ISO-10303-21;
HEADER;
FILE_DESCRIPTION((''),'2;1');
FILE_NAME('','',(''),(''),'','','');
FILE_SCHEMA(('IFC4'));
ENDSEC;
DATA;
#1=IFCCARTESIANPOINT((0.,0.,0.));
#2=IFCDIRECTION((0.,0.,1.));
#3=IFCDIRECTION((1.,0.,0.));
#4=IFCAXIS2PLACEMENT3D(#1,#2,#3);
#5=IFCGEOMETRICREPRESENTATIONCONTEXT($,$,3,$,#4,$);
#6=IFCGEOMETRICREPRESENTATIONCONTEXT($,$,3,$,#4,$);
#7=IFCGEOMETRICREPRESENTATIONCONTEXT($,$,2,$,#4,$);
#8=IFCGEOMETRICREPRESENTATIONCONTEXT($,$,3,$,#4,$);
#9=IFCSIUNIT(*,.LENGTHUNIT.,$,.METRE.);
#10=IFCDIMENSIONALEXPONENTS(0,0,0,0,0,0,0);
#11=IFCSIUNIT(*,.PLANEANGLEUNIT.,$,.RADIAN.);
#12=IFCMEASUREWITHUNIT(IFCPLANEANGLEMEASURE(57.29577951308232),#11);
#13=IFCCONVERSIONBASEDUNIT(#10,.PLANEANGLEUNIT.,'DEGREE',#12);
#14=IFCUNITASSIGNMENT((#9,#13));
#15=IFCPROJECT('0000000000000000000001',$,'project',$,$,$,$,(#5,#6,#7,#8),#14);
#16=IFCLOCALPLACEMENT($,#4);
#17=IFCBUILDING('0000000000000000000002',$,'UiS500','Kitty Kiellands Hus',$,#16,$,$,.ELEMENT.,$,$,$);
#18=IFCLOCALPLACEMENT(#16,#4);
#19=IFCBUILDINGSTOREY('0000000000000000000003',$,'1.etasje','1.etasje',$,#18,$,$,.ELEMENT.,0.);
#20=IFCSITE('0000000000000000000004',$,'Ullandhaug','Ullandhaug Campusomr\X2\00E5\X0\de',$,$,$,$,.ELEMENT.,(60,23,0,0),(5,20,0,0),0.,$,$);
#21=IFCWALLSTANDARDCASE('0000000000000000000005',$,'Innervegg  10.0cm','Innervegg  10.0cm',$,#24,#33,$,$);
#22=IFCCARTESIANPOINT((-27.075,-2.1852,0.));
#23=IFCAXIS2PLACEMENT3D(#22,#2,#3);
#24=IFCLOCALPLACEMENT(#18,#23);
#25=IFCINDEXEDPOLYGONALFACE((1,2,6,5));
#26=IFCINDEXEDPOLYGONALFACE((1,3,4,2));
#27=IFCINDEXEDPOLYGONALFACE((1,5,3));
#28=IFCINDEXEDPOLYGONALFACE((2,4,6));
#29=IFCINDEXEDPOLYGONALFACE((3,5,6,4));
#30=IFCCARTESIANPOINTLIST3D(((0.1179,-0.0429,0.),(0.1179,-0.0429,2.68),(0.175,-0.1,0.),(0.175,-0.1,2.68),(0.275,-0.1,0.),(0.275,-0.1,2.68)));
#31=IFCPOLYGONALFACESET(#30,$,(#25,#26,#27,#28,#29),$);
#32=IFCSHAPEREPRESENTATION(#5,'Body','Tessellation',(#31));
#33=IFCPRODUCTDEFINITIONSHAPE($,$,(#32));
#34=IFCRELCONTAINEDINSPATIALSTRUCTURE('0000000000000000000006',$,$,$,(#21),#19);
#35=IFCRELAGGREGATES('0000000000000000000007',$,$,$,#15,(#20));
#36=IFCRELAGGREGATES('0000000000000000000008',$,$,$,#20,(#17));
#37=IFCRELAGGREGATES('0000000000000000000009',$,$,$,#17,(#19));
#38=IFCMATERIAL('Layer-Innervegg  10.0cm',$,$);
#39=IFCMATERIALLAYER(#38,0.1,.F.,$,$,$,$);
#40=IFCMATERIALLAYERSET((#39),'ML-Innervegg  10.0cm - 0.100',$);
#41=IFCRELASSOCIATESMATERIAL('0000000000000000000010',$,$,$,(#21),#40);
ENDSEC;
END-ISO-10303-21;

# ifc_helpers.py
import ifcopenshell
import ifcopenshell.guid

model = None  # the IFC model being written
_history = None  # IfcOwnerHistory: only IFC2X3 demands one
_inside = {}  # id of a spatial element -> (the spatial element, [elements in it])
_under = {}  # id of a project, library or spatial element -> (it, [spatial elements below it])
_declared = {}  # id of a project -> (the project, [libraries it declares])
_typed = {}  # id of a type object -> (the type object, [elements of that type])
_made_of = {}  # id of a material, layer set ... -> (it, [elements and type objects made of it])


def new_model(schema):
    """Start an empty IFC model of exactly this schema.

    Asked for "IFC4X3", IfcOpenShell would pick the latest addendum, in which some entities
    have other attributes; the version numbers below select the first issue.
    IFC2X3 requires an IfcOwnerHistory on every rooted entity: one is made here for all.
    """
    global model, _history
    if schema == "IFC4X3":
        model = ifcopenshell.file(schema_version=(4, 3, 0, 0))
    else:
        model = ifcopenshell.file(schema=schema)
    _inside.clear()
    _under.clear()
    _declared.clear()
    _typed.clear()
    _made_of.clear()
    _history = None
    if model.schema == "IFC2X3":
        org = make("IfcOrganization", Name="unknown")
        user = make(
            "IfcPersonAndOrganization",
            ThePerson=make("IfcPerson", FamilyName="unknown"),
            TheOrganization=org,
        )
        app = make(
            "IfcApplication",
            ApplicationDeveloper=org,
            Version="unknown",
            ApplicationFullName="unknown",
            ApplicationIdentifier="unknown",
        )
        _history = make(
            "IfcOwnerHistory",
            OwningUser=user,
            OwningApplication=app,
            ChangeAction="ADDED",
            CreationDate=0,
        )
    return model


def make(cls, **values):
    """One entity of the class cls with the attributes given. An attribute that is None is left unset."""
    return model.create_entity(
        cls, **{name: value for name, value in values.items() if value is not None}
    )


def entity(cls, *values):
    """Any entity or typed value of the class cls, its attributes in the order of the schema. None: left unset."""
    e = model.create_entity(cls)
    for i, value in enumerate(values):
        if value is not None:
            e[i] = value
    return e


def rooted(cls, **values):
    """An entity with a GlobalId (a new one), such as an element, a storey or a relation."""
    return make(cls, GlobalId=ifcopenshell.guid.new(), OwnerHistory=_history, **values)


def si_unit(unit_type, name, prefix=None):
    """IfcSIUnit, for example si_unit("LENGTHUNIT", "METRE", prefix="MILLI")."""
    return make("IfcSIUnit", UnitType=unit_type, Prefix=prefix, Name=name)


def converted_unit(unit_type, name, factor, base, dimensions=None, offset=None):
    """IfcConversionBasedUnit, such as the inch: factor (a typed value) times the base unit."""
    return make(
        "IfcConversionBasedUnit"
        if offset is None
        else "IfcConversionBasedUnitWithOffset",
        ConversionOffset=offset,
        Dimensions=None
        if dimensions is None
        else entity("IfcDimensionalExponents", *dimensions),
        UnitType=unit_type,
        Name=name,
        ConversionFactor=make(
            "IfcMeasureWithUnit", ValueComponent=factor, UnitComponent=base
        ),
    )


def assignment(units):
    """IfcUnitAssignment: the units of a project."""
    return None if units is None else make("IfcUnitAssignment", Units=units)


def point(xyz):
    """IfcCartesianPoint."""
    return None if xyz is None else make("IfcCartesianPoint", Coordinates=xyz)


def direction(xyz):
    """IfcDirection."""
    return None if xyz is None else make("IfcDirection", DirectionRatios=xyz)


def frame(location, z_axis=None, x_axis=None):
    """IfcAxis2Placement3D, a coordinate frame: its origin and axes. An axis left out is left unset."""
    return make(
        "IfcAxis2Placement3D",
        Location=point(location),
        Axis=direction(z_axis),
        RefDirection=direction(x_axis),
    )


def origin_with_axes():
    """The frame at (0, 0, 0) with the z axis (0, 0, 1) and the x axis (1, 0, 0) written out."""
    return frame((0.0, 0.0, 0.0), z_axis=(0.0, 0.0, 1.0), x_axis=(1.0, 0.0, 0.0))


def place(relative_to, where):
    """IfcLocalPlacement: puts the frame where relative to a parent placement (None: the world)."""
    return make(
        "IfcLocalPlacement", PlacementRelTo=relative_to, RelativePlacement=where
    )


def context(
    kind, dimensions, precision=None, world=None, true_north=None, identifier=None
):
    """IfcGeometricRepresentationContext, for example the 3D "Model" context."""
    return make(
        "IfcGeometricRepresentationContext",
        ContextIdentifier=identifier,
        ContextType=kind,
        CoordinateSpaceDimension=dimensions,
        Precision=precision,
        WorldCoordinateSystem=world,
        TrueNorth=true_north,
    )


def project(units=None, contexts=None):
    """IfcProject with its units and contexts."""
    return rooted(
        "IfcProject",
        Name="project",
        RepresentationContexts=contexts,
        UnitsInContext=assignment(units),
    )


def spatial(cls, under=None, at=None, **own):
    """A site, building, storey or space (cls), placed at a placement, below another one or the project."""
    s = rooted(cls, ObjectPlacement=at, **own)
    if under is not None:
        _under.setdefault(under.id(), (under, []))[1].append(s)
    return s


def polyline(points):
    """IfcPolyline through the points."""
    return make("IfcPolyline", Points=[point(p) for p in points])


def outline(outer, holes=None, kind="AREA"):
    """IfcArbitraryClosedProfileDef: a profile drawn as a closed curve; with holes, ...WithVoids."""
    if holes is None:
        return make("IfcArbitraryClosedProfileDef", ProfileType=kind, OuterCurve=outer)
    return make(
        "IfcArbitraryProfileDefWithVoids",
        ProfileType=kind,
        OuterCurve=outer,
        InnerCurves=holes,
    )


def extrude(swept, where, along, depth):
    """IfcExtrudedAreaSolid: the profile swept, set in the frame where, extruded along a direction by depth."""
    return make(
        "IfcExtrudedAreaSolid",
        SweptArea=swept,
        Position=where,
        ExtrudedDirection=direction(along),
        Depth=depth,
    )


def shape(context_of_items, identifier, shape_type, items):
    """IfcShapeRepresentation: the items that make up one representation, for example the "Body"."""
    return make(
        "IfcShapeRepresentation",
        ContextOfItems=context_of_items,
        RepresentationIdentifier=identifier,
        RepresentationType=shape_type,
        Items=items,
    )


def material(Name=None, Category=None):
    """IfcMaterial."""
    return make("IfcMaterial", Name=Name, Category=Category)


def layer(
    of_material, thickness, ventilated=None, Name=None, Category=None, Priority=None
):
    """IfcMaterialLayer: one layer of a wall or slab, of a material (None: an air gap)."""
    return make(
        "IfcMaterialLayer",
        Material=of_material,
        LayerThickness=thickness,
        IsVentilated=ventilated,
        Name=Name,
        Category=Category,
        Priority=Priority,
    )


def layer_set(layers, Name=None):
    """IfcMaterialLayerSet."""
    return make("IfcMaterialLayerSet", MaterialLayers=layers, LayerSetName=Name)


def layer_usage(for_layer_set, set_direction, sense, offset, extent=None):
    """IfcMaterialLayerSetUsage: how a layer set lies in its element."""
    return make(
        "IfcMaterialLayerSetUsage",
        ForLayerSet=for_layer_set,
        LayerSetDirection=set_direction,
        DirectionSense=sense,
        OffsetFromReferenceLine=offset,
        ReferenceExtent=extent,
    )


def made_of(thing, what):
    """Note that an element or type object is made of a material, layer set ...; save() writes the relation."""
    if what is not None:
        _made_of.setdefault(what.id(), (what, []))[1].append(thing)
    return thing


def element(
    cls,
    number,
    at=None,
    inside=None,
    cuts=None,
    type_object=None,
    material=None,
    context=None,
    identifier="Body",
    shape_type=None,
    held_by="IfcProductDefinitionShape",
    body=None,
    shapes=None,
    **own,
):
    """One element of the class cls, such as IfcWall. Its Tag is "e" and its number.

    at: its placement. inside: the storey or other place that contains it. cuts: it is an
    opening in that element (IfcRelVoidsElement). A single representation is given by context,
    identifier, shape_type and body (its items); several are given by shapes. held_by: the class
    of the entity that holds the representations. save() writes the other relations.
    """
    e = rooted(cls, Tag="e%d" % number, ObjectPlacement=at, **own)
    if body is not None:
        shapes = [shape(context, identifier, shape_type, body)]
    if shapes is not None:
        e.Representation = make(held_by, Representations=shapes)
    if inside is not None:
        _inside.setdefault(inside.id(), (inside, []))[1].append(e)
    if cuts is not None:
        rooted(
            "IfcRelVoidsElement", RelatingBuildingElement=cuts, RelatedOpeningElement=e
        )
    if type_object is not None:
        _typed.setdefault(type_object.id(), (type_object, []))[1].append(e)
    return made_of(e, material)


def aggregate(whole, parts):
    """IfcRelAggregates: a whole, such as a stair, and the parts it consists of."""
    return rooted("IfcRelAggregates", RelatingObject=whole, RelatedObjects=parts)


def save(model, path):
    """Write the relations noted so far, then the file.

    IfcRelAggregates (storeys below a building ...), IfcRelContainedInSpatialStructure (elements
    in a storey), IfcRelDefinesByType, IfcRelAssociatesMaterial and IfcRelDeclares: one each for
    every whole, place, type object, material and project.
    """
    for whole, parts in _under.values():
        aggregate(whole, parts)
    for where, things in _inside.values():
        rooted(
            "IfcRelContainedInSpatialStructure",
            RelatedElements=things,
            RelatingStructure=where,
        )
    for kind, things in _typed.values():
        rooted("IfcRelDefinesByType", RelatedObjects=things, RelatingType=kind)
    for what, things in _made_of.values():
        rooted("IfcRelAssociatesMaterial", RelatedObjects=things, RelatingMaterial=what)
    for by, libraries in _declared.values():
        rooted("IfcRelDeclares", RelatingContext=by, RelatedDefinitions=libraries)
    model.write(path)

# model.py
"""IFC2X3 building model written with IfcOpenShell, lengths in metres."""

from ifc_helpers import new_model, entity, si_unit, converted_unit, frame, origin_with_axes, place, context, project, spatial, polyline, outline, extrude, material, layer, layer_set, layer_usage, element, save


model = new_model("IFC2X3")

# Units and contexts
context_of_model_1 = context(None, 3, world=origin_with_axes())
context_of_model_2 = context(None, 3, world=origin_with_axes())
context_of_model_3 = context(None, 2, world=origin_with_axes())
context_of_model_4 = context(None, 3, world=origin_with_axes())
ifc_project = project(units=[si_unit("LENGTHUNIT", "METRE"), converted_unit("PLANEANGLEUNIT", "DEGREE", entity("IfcPlaneAngleMeasure", 57.29577951308232), si_unit("PLANEANGLEUNIT", "RADIAN"), dimensions=[0, 0, 0, 0, 0, 0, 0])], contexts=[context_of_model_1, context_of_model_2, context_of_model_3, context_of_model_4])

# Site, building, storey
site = spatial("IfcSite", under=ifc_project, Name="Ullandhaug", Description="Ullandhaug Campusområde", CompositionType="ELEMENT", RefLatitude=(60, 23, 0, 0), RefLongitude=(5, 20, 0, 0), RefElevation=0.0)
building_placement = place(None, origin_with_axes())
building = spatial("IfcBuilding", under=site, at=building_placement, Name="UiS500", Description="Kitty Kiellands Hus", CompositionType="ELEMENT")
storey_placement = place(building_placement, origin_with_axes())
storey = spatial("IfcBuildingStorey", under=building, at=storey_placement, Name="1.etasje", Description="1.etasje", CompositionType="ELEMENT", Elevation=0.0)

# Shared definitions
ifc_material_1 = material(Name="Layer-Innervegg  10.0cm")
ifc_layer_1 = layer(ifc_material_1, 0.1, ventilated=False)
ifc_layer_set_1 = layer_set([ifc_layer_1], Name="ML-Innervegg  10.0cm - 0.100")
ifc_layer_usage_1 = layer_usage(ifc_layer_set_1, "AXIS2", "POSITIVE", 0.0)

# Wall
wall_1_placement = place(storey_placement, frame((-27.075, -2.1852, 0.0), z_axis=(0.0, 0.0, 1.0), x_axis=(1.0, 0.0, 0.0)))
element("IfcWallStandardCase", 1, at=wall_1_placement, inside=storey, material=ifc_layer_usage_1, Name="Innervegg  10.0cm", Description="Innervegg  10.0cm", context=context_of_model_1, shape_type="SweptSolid", body=[
    extrude(outline(polyline([(0.0, 0.0), (0.075, 0.0), (0.175, 0.1), (0.275, 0.1), (0.0, 0.0)])), frame((0.0, 0.0, 0.0), z_axis=(0.0, 0.0, -1.0), x_axis=(1.0, 0.0, 0.0)), (0.0, 0.0, -1.0), 2.68),
])

save(model, "model.ifc")
